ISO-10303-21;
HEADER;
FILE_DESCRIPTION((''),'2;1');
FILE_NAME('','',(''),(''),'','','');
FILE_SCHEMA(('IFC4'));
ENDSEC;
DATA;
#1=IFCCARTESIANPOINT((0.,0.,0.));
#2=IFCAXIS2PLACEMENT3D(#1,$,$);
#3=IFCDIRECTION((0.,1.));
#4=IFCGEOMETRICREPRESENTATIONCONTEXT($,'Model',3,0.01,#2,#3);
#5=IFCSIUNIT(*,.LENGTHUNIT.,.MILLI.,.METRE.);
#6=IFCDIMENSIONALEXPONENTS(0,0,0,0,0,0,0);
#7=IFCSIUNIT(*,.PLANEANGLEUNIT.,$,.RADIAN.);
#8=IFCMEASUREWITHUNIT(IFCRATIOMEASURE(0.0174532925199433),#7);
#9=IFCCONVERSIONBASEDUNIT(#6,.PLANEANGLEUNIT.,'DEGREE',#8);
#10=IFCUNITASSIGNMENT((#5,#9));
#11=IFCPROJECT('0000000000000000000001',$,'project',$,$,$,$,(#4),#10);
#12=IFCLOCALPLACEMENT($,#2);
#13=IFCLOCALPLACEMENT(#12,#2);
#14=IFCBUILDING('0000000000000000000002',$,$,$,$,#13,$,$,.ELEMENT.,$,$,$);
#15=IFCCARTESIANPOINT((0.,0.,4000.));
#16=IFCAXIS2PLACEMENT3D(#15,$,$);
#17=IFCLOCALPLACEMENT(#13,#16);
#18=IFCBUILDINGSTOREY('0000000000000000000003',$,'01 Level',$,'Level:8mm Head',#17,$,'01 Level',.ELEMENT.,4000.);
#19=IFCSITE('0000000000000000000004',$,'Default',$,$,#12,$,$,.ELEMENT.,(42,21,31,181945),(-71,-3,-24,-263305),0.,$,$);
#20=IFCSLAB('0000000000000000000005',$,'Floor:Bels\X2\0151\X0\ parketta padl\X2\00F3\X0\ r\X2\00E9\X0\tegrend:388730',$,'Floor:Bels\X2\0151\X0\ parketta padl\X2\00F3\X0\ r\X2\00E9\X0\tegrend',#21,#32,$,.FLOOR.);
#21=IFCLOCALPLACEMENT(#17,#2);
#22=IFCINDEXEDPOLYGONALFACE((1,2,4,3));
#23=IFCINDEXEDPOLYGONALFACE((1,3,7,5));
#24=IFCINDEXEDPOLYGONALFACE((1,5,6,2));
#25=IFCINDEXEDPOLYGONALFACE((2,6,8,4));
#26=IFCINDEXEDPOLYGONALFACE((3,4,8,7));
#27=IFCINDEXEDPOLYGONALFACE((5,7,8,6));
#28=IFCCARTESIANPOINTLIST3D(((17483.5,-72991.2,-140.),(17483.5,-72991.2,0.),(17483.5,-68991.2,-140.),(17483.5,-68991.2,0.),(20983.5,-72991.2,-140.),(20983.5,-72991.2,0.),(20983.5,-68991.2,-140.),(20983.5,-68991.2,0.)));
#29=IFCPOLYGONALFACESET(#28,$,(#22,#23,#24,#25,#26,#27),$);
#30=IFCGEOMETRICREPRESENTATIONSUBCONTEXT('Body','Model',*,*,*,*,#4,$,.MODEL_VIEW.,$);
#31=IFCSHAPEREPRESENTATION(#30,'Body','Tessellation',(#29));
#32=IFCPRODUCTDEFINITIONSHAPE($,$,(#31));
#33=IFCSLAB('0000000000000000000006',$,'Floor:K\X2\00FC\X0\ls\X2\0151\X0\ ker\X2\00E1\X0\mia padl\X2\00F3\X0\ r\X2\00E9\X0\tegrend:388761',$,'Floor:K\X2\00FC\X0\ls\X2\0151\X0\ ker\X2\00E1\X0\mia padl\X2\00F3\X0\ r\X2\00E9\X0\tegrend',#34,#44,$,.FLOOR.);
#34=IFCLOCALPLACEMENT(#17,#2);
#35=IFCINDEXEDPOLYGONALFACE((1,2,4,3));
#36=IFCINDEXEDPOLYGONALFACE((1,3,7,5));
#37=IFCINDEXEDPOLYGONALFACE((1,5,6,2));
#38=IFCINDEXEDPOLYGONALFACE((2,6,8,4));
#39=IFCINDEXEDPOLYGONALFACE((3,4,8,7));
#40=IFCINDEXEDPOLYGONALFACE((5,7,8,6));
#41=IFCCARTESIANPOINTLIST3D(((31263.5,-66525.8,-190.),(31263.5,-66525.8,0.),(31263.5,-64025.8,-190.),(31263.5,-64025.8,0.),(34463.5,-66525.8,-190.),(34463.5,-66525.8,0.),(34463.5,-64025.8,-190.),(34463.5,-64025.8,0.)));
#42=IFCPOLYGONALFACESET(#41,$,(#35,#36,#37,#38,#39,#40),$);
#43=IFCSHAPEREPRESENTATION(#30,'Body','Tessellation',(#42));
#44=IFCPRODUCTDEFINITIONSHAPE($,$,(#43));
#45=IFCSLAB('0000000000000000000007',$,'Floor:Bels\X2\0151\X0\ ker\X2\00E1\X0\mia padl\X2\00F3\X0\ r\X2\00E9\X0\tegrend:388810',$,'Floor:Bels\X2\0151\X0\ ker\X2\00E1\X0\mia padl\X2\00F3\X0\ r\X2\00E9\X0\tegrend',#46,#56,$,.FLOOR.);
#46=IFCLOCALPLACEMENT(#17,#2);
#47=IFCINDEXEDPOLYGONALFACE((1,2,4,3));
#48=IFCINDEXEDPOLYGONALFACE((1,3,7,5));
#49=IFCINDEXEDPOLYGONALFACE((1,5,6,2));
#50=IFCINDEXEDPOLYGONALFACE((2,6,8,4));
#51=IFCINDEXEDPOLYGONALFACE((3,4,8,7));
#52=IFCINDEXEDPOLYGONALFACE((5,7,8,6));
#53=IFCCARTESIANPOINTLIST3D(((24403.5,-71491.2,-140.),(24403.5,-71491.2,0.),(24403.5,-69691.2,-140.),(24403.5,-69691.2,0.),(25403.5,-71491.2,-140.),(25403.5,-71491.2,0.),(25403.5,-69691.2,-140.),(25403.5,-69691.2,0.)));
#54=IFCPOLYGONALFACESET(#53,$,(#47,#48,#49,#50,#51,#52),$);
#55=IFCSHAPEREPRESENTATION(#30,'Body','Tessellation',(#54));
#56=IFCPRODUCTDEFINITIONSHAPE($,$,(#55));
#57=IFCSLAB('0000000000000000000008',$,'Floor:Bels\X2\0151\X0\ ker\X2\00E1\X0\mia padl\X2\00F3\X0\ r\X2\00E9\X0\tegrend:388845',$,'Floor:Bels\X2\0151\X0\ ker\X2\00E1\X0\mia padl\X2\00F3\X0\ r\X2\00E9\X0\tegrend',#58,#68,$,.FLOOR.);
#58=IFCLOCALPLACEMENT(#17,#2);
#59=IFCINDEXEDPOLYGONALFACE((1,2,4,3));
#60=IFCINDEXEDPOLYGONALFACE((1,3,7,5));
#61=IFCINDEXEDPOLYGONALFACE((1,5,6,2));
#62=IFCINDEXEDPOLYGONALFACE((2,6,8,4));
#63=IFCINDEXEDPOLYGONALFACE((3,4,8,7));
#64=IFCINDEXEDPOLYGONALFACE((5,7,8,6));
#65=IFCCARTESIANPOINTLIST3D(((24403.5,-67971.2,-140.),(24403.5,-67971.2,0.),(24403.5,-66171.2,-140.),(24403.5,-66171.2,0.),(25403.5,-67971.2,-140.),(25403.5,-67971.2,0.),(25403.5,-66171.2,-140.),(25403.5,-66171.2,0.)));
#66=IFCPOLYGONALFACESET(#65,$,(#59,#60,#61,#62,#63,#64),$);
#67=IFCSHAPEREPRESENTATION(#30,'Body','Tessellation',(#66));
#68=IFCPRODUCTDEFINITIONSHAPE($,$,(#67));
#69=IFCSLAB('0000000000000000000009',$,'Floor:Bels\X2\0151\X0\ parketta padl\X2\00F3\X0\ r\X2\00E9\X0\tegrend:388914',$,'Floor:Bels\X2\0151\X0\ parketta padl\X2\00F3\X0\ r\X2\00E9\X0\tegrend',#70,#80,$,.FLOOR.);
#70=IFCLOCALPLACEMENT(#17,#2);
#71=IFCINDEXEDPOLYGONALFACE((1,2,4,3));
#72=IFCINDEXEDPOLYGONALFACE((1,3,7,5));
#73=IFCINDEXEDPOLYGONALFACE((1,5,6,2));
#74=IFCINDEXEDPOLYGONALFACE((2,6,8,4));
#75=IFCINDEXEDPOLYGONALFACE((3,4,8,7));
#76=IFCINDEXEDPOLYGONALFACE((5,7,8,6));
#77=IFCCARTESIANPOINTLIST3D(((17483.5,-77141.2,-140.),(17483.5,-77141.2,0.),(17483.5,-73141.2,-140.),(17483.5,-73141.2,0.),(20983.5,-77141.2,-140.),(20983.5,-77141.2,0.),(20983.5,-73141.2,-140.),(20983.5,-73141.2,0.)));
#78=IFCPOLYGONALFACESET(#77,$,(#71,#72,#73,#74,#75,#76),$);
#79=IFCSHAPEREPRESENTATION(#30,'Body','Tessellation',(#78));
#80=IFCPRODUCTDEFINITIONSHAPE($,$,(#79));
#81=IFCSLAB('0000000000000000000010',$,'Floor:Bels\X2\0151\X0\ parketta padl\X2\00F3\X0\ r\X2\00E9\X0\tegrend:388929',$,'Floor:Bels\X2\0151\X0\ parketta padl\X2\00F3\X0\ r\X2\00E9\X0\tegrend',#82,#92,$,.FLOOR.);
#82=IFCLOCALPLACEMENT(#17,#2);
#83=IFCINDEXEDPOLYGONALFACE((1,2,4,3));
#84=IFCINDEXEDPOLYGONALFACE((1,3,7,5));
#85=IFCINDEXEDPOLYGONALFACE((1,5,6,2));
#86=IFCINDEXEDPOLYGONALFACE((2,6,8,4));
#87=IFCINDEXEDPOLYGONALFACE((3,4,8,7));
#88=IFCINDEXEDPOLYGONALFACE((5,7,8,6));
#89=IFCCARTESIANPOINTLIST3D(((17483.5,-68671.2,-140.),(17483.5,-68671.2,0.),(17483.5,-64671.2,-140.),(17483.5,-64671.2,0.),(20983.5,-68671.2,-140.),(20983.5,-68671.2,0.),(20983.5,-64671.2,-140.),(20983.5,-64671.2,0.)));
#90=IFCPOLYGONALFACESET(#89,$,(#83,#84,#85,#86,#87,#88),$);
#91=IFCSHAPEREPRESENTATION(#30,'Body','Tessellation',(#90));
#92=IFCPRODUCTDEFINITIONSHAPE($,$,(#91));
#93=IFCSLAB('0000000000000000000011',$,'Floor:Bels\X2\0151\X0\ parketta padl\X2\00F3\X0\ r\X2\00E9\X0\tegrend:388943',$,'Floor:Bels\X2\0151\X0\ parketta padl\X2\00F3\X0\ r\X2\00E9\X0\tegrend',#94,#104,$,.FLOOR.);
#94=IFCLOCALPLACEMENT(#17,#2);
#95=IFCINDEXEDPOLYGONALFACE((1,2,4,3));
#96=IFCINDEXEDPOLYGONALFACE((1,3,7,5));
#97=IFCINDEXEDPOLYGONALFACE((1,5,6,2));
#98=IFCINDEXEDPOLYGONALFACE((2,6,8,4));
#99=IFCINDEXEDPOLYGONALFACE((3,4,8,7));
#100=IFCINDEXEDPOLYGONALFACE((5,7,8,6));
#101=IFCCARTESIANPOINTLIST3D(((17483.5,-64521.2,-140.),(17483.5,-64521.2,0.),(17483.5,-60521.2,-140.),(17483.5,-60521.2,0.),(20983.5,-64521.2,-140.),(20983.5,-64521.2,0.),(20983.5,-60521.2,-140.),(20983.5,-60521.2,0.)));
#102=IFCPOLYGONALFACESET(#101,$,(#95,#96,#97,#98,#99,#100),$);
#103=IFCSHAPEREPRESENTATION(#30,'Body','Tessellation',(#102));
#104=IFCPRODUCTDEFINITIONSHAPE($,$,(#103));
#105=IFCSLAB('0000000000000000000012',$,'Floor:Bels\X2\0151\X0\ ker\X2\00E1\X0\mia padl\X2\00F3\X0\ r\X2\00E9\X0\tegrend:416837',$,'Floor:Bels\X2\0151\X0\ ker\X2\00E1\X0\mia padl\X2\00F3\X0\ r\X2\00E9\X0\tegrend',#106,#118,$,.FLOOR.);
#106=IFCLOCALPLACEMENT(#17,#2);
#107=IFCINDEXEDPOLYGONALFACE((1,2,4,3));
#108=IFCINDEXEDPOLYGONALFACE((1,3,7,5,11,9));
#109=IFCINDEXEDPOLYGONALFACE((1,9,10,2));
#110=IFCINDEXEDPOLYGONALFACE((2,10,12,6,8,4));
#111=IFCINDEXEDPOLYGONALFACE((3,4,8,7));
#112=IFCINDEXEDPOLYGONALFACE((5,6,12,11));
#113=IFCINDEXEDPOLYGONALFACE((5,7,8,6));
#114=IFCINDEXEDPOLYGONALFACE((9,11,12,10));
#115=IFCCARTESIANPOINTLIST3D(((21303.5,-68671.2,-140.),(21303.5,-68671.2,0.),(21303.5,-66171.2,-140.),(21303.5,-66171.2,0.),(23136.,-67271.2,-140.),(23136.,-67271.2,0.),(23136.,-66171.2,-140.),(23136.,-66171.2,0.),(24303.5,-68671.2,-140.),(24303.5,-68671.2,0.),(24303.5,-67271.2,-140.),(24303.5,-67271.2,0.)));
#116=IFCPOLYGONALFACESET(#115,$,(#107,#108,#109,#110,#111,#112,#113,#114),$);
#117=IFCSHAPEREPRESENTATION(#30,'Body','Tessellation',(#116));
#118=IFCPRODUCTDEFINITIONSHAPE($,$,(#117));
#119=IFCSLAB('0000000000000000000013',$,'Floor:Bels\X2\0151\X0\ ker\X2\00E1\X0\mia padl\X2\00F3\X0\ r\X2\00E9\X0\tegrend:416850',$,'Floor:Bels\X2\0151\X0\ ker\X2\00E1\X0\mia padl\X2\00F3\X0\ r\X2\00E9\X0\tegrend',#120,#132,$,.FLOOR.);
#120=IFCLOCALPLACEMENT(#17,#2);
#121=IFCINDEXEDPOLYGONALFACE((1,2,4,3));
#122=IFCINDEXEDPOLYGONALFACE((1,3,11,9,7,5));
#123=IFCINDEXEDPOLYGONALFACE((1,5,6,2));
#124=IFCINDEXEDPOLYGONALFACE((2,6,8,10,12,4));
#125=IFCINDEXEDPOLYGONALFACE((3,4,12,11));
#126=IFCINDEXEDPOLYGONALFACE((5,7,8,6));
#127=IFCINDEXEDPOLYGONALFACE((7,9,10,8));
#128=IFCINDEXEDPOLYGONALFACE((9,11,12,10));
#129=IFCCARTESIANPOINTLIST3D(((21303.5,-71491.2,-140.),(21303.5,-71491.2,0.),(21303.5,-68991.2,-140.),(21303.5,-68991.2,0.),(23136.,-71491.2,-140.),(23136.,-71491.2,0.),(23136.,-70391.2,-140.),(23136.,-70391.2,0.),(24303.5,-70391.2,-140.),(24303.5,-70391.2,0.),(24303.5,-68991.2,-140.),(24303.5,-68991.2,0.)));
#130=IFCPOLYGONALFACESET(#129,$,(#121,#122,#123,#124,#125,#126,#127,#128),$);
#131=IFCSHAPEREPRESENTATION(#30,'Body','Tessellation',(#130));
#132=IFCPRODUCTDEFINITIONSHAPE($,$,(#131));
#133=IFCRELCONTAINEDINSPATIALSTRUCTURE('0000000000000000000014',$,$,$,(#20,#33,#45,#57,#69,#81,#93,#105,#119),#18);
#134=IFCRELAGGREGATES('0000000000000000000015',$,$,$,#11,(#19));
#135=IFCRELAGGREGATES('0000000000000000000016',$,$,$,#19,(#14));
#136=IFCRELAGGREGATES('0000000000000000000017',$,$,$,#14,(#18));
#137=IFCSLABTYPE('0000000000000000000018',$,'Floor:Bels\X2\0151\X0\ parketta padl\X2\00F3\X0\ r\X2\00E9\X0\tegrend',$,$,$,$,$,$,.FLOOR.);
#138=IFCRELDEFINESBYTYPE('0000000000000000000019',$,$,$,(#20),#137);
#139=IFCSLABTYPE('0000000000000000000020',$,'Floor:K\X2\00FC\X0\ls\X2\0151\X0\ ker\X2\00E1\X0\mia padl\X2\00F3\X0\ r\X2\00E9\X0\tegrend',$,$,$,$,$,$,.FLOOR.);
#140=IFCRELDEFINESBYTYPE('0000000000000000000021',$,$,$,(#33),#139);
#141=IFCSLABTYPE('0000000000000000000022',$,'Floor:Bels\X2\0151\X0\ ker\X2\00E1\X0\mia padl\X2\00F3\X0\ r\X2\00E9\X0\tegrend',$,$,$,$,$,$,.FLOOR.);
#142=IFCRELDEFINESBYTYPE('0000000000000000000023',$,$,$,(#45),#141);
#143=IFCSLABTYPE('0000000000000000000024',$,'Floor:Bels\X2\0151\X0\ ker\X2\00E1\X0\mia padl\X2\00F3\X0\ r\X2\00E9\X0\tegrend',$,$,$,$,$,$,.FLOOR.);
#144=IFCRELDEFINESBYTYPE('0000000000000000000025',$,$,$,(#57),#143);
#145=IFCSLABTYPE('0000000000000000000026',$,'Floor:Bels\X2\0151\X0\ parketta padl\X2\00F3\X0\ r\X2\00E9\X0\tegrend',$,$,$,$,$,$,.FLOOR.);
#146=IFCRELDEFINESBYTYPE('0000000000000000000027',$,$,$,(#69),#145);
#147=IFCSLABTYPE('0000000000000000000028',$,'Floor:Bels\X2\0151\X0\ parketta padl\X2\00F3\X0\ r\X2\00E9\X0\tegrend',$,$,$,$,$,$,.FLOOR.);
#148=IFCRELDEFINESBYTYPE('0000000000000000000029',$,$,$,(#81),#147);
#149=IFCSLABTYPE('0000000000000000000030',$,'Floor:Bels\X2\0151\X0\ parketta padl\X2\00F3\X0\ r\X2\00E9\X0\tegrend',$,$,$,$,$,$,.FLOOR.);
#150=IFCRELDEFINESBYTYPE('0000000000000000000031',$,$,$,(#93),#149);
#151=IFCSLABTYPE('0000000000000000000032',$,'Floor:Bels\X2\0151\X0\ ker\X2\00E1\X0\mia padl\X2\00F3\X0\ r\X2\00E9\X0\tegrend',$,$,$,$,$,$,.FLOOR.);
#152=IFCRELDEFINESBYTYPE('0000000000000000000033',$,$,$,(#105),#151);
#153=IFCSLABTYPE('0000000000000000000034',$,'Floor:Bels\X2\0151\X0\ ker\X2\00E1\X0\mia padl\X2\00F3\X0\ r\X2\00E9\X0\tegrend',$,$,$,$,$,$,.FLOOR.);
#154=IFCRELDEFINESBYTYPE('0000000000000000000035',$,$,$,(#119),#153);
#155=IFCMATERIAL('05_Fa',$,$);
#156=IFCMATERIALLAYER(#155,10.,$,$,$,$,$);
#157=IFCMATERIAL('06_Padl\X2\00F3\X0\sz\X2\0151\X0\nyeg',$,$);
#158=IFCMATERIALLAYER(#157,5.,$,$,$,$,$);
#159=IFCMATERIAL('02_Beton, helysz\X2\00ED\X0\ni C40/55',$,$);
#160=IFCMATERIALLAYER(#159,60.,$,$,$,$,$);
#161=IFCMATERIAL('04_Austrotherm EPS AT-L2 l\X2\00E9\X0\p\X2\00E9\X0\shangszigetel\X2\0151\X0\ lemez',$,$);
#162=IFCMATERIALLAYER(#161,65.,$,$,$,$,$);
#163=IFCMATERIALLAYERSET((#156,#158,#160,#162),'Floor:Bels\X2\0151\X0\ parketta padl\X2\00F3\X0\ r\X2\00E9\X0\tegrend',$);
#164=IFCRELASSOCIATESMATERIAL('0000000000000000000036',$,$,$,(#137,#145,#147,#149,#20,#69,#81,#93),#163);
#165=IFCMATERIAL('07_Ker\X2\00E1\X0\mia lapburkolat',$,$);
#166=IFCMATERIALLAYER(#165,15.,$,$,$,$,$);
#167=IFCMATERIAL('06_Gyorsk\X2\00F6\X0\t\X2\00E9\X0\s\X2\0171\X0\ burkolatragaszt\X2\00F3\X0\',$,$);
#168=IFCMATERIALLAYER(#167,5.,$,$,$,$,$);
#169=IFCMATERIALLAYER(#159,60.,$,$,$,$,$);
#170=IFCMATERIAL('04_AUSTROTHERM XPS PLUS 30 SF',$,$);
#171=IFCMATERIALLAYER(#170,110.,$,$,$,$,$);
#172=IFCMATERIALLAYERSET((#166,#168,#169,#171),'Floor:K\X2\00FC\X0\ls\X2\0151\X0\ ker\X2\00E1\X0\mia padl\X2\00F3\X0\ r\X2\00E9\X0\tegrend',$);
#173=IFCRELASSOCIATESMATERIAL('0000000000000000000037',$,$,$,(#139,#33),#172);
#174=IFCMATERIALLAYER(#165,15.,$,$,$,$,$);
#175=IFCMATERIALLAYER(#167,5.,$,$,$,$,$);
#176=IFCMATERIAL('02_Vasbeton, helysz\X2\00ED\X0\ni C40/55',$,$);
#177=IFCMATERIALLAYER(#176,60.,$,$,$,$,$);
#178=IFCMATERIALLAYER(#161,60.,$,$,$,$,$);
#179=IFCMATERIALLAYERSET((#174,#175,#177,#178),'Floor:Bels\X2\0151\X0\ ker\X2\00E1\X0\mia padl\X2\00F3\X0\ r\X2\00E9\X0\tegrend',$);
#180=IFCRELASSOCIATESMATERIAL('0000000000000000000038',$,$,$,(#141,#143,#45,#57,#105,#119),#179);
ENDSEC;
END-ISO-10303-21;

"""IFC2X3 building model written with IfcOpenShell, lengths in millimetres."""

from ifc_helpers import new_model, entity, si_unit, converted_unit, direction, frame, frame_2d, origin, origin_2d_with_axis, place, context, subcontext, project, spatial, polyline, rectangle, outline, extrude, material, layer, layer_set, layer_usage, type_object, element, save


model = new_model("IFC2X3")

# Units and contexts
model_context = context("Model", 3, precision=0.01, world=origin(), true_north=direction((0.0, 1.0)))
body_context = subcontext(model_context, "Body", "Model", "MODEL_VIEW")
ifc_project = project(units=[si_unit("LENGTHUNIT", "METRE", prefix="MILLI"), converted_unit("PLANEANGLEUNIT", "DEGREE", entity("IfcRatioMeasure", 0.0174532925199433), si_unit("PLANEANGLEUNIT", "RADIAN"), dimensions=[0, 0, 0, 0, 0, 0, 0])], contexts=[model_context])

# Site, building, storey
site_placement = place(None, origin())
site = spatial("IfcSite", under=ifc_project, at=site_placement, Name="Default", CompositionType="ELEMENT", RefLatitude=(42, 21, 31, 181945), RefLongitude=(-71, -3, -24, -263305), RefElevation=0.0)
building_placement = place(site_placement, origin())
building = spatial("IfcBuilding", under=site, at=building_placement, CompositionType="ELEMENT")
storey_placement = place(building_placement, frame((0.0, 0.0, 4000.0)))
storey = spatial("IfcBuildingStorey", under=building, at=storey_placement, Name="01 Level", ObjectType="Level:8mm Head", LongName="01 Level", CompositionType="ELEMENT", Elevation=4000.0)

# Slabs
ifc_material_1 = material(Name="05_Fa")
ifc_layer_1 = layer(ifc_material_1, 10.0)
ifc_material_2 = material(Name="06_Padlószőnyeg")
ifc_layer_2 = layer(ifc_material_2, 5.0)
ifc_material_3 = material(Name="02_Beton, helyszíni C40/55")
ifc_layer_3 = layer(ifc_material_3, 60.0)
ifc_material_4 = material(Name="04_Austrotherm EPS AT-L2 lépéshangszigetelő lemez")
ifc_layer_4 = layer(ifc_material_4, 65.0)
ifc_layer_set_1 = layer_set([ifc_layer_1, ifc_layer_2, ifc_layer_3, ifc_layer_4], Name="Floor:Belső parketta padló rétegrend")
ifc_layer_usage_1 = layer_usage(ifc_layer_set_1, "AXIS3", "POSITIVE", 0.0)
slab_type_1 = type_object("IfcSlabType", Name="Floor:Belső parketta padló rétegrend", PredefinedType="FLOOR", material=ifc_layer_set_1)
slab_1_placement = place(storey_placement, origin())
element("IfcSlab", 1, at=slab_1_placement, inside=storey, type_object=slab_type_1, material=ifc_layer_usage_1, Name="Floor:Belső parketta padló rétegrend:388730", ObjectType="Floor:Belső parketta padló rétegrend", PredefinedType="FLOOR", context=body_context, shape_type="SweptSolid", body=[
    extrude(rectangle(XDim=4000.0, YDim=3500.0, at=frame_2d((0.0, 0.0), x_axis=(1.0, 0.0))), frame((19233.5, -70991.2, 0.0), z_axis=(0.0, 0.0, -1.0), x_axis=(0.0, 1.0, 0.0)), (0.0, 0.0, 1.0), 140.0),
])
ifc_material_5 = material(Name="07_Kerámia lapburkolat")
ifc_layer_5 = layer(ifc_material_5, 15.0)
ifc_material_6 = material(Name="06_Gyorskötésű burkolatragasztó")
ifc_layer_6 = layer(ifc_material_6, 5.0)
ifc_layer_7 = layer(ifc_material_3, 60.0)
ifc_material_7 = material(Name="04_AUSTROTHERM XPS PLUS 30 SF")
ifc_layer_8 = layer(ifc_material_7, 110.0)
ifc_layer_set_2 = layer_set([ifc_layer_5, ifc_layer_6, ifc_layer_7, ifc_layer_8], Name="Floor:Külső kerámia padló rétegrend")
ifc_layer_usage_2 = layer_usage(ifc_layer_set_2, "AXIS3", "POSITIVE", 0.0)
slab_type_2 = type_object("IfcSlabType", Name="Floor:Külső kerámia padló rétegrend", PredefinedType="FLOOR", material=ifc_layer_set_2)
slab_2_placement = place(storey_placement, origin())
element("IfcSlab", 2, at=slab_2_placement, inside=storey, type_object=slab_type_2, material=ifc_layer_usage_2, Name="Floor:Külső kerámia padló rétegrend:388761", ObjectType="Floor:Külső kerámia padló rétegrend", PredefinedType="FLOOR", context=body_context, shape_type="SweptSolid", body=[
    extrude(rectangle(XDim=2500.0, YDim=3200.0, at=origin_2d_with_axis()), frame((32863.5, -65275.8, 0.0), z_axis=(0.0, 0.0, -1.0), x_axis=(0.0, 1.0, 0.0)), (0.0, 0.0, 1.0), 190.0),
])
ifc_layer_9 = layer(ifc_material_5, 15.0)
ifc_layer_10 = layer(ifc_material_6, 5.0)
ifc_material_8 = material(Name="02_Vasbeton, helyszíni C40/55")
ifc_layer_11 = layer(ifc_material_8, 60.0)
ifc_layer_12 = layer(ifc_material_4, 60.0)
ifc_layer_set_3 = layer_set([ifc_layer_9, ifc_layer_10, ifc_layer_11, ifc_layer_12], Name="Floor:Belső kerámia padló rétegrend")
ifc_layer_usage_3 = layer_usage(ifc_layer_set_3, "AXIS3", "POSITIVE", 0.0)
slab_type_3 = type_object("IfcSlabType", Name="Floor:Belső kerámia padló rétegrend", PredefinedType="FLOOR", material=ifc_layer_set_3)
slab_3_placement = place(storey_placement, origin())
element("IfcSlab", 3, at=slab_3_placement, inside=storey, type_object=slab_type_3, material=ifc_layer_usage_3, Name="Floor:Belső kerámia padló rétegrend:388810", ObjectType="Floor:Belső kerámia padló rétegrend", PredefinedType="FLOOR", context=body_context, shape_type="SweptSolid", body=[
    extrude(rectangle(XDim=1800.0, YDim=1000.0, at=frame_2d((0.0, 0.0), x_axis=(1.0, 0.0))), frame((24903.5, -70591.2, 0.0), z_axis=(0.0, 0.0, -1.0), x_axis=(0.0, 1.0, 0.0)), (0.0, 0.0, 1.0), 140.0),
])
ifc_layer_usage_4 = layer_usage(ifc_layer_set_3, "AXIS3", "POSITIVE", 0.0)
slab_type_4 = type_object("IfcSlabType", Name="Floor:Belső kerámia padló rétegrend", PredefinedType="FLOOR", material=ifc_layer_set_3)
slab_4_placement = place(storey_placement, origin())
element("IfcSlab", 4, at=slab_4_placement, inside=storey, type_object=slab_type_4, material=ifc_layer_usage_4, Name="Floor:Belső kerámia padló rétegrend:388845", ObjectType="Floor:Belső kerámia padló rétegrend", PredefinedType="FLOOR", context=body_context, shape_type="SweptSolid", body=[
    extrude(rectangle(XDim=1800.0, YDim=1000.0, at=frame_2d((0.0, 0.0), x_axis=(1.0, 0.0))), frame((24903.5, -67071.2, 0.0), z_axis=(0.0, 0.0, -1.0), x_axis=(0.0, 1.0, 0.0)), (0.0, 0.0, 1.0), 140.0),
])
ifc_layer_usage_5 = layer_usage(ifc_layer_set_1, "AXIS3", "POSITIVE", 0.0)
slab_type_5 = type_object("IfcSlabType", Name="Floor:Belső parketta padló rétegrend", PredefinedType="FLOOR", material=ifc_layer_set_1)
slab_5_placement = place(storey_placement, origin())
element("IfcSlab", 5, at=slab_5_placement, inside=storey, type_object=slab_type_5, material=ifc_layer_usage_5, Name="Floor:Belső parketta padló rétegrend:388914", ObjectType="Floor:Belső parketta padló rétegrend", PredefinedType="FLOOR", context=body_context, shape_type="SweptSolid", body=[
    extrude(rectangle(XDim=4000.0, YDim=3500.0, at=frame_2d((0.0, 0.0), x_axis=(1.0, 0.0))), frame((19233.5, -75141.2, 0.0), z_axis=(0.0, 0.0, -1.0), x_axis=(0.0, 1.0, 0.0)), (0.0, 0.0, 1.0), 140.0),
])
ifc_layer_usage_6 = layer_usage(ifc_layer_set_1, "AXIS3", "POSITIVE", 0.0)
slab_type_6 = type_object("IfcSlabType", Name="Floor:Belső parketta padló rétegrend", PredefinedType="FLOOR", material=ifc_layer_set_1)
slab_6_placement = place(storey_placement, origin())
element("IfcSlab", 6, at=slab_6_placement, inside=storey, type_object=slab_type_6, material=ifc_layer_usage_6, Name="Floor:Belső parketta padló rétegrend:388929", ObjectType="Floor:Belső parketta padló rétegrend", PredefinedType="FLOOR", context=body_context, shape_type="SweptSolid", body=[
    extrude(rectangle(XDim=4000.0, YDim=3500.0, at=frame_2d((0.0, 0.0), x_axis=(1.0, 0.0))), frame((19233.5, -66671.2, 0.0), z_axis=(0.0, 0.0, -1.0), x_axis=(0.0, 1.0, 0.0)), (0.0, 0.0, 1.0), 140.0),
])
ifc_layer_usage_7 = layer_usage(ifc_layer_set_1, "AXIS3", "POSITIVE", 0.0)
slab_type_7 = type_object("IfcSlabType", Name="Floor:Belső parketta padló rétegrend", PredefinedType="FLOOR", material=ifc_layer_set_1)
slab_7_placement = place(storey_placement, origin())
element("IfcSlab", 7, at=slab_7_placement, inside=storey, type_object=slab_type_7, material=ifc_layer_usage_7, Name="Floor:Belső parketta padló rétegrend:388943", ObjectType="Floor:Belső parketta padló rétegrend", PredefinedType="FLOOR", context=body_context, shape_type="SweptSolid", body=[
    extrude(rectangle(XDim=4000.0, YDim=3500.0, at=frame_2d((0.0, 0.0), x_axis=(1.0, 0.0))), frame((19233.5, -62521.2, 0.0), z_axis=(0.0, 0.0, -1.0), x_axis=(0.0, 1.0, 0.0)), (0.0, 0.0, 1.0), 140.0),
])
ifc_layer_usage_8 = layer_usage(ifc_layer_set_3, "AXIS3", "POSITIVE", 0.0)
slab_type_8 = type_object("IfcSlabType", Name="Floor:Belső kerámia padló rétegrend", PredefinedType="FLOOR")
slab_8_placement = place(storey_placement, frame((21303.5, -68671.2, -140.0)))
element("IfcSlab", 8, at=slab_8_placement, inside=storey, type_object=slab_type_8, material=ifc_layer_usage_8, Name="Floor:Belső kerámia padló rétegrend:416837", ObjectType="Floor:Belső kerámia padló rétegrend", PredefinedType="FLOOR", context=body_context, shape_type="SweptSolid", body=[
    extrude(outline(polyline([(-1500.0, -1250.0), (1500.0, -1250.0), (1500.0, 1250.0), (-332.5, 1250.0), (-332.5, 150.0), (-1500.0, 150.0), (-1500.0, -1250.0)])), frame((1500.0, 1250.0, 140.0), z_axis=(0.0, 0.0, -1.0), x_axis=(-1.0, 0.0, 0.0)), (0.0, 0.0, 1.0), 140.0),
])
ifc_layer_usage_9 = layer_usage(ifc_layer_set_3, "AXIS3", "POSITIVE", 0.0)
slab_type_9 = type_object("IfcSlabType", Name="Floor:Belső kerámia padló rétegrend", PredefinedType="FLOOR")
slab_9_placement = place(storey_placement, frame((21303.5, -71491.2, -140.0)))
element("IfcSlab", 9, at=slab_9_placement, inside=storey, type_object=slab_type_9, material=ifc_layer_usage_9, Name="Floor:Belső kerámia padló rétegrend:416850", ObjectType="Floor:Belső kerámia padló rétegrend", PredefinedType="FLOOR", context=body_context, shape_type="SweptSolid", body=[
    extrude(outline(polyline([(-1500.0, 1250.0), (-1500.0, -150.0), (-332.5, -150.0), (-332.5, -1250.0), (1500.0, -1250.0), (1500.0, 1250.0), (-1500.0, 1250.0)])), frame((1500.0, 1250.0, 140.0), z_axis=(0.0, 0.0, -1.0), x_axis=(-1.0, 0.0, 0.0)), (0.0, 0.0, 1.0), 140.0),
])

save(model, "model.ifc")
